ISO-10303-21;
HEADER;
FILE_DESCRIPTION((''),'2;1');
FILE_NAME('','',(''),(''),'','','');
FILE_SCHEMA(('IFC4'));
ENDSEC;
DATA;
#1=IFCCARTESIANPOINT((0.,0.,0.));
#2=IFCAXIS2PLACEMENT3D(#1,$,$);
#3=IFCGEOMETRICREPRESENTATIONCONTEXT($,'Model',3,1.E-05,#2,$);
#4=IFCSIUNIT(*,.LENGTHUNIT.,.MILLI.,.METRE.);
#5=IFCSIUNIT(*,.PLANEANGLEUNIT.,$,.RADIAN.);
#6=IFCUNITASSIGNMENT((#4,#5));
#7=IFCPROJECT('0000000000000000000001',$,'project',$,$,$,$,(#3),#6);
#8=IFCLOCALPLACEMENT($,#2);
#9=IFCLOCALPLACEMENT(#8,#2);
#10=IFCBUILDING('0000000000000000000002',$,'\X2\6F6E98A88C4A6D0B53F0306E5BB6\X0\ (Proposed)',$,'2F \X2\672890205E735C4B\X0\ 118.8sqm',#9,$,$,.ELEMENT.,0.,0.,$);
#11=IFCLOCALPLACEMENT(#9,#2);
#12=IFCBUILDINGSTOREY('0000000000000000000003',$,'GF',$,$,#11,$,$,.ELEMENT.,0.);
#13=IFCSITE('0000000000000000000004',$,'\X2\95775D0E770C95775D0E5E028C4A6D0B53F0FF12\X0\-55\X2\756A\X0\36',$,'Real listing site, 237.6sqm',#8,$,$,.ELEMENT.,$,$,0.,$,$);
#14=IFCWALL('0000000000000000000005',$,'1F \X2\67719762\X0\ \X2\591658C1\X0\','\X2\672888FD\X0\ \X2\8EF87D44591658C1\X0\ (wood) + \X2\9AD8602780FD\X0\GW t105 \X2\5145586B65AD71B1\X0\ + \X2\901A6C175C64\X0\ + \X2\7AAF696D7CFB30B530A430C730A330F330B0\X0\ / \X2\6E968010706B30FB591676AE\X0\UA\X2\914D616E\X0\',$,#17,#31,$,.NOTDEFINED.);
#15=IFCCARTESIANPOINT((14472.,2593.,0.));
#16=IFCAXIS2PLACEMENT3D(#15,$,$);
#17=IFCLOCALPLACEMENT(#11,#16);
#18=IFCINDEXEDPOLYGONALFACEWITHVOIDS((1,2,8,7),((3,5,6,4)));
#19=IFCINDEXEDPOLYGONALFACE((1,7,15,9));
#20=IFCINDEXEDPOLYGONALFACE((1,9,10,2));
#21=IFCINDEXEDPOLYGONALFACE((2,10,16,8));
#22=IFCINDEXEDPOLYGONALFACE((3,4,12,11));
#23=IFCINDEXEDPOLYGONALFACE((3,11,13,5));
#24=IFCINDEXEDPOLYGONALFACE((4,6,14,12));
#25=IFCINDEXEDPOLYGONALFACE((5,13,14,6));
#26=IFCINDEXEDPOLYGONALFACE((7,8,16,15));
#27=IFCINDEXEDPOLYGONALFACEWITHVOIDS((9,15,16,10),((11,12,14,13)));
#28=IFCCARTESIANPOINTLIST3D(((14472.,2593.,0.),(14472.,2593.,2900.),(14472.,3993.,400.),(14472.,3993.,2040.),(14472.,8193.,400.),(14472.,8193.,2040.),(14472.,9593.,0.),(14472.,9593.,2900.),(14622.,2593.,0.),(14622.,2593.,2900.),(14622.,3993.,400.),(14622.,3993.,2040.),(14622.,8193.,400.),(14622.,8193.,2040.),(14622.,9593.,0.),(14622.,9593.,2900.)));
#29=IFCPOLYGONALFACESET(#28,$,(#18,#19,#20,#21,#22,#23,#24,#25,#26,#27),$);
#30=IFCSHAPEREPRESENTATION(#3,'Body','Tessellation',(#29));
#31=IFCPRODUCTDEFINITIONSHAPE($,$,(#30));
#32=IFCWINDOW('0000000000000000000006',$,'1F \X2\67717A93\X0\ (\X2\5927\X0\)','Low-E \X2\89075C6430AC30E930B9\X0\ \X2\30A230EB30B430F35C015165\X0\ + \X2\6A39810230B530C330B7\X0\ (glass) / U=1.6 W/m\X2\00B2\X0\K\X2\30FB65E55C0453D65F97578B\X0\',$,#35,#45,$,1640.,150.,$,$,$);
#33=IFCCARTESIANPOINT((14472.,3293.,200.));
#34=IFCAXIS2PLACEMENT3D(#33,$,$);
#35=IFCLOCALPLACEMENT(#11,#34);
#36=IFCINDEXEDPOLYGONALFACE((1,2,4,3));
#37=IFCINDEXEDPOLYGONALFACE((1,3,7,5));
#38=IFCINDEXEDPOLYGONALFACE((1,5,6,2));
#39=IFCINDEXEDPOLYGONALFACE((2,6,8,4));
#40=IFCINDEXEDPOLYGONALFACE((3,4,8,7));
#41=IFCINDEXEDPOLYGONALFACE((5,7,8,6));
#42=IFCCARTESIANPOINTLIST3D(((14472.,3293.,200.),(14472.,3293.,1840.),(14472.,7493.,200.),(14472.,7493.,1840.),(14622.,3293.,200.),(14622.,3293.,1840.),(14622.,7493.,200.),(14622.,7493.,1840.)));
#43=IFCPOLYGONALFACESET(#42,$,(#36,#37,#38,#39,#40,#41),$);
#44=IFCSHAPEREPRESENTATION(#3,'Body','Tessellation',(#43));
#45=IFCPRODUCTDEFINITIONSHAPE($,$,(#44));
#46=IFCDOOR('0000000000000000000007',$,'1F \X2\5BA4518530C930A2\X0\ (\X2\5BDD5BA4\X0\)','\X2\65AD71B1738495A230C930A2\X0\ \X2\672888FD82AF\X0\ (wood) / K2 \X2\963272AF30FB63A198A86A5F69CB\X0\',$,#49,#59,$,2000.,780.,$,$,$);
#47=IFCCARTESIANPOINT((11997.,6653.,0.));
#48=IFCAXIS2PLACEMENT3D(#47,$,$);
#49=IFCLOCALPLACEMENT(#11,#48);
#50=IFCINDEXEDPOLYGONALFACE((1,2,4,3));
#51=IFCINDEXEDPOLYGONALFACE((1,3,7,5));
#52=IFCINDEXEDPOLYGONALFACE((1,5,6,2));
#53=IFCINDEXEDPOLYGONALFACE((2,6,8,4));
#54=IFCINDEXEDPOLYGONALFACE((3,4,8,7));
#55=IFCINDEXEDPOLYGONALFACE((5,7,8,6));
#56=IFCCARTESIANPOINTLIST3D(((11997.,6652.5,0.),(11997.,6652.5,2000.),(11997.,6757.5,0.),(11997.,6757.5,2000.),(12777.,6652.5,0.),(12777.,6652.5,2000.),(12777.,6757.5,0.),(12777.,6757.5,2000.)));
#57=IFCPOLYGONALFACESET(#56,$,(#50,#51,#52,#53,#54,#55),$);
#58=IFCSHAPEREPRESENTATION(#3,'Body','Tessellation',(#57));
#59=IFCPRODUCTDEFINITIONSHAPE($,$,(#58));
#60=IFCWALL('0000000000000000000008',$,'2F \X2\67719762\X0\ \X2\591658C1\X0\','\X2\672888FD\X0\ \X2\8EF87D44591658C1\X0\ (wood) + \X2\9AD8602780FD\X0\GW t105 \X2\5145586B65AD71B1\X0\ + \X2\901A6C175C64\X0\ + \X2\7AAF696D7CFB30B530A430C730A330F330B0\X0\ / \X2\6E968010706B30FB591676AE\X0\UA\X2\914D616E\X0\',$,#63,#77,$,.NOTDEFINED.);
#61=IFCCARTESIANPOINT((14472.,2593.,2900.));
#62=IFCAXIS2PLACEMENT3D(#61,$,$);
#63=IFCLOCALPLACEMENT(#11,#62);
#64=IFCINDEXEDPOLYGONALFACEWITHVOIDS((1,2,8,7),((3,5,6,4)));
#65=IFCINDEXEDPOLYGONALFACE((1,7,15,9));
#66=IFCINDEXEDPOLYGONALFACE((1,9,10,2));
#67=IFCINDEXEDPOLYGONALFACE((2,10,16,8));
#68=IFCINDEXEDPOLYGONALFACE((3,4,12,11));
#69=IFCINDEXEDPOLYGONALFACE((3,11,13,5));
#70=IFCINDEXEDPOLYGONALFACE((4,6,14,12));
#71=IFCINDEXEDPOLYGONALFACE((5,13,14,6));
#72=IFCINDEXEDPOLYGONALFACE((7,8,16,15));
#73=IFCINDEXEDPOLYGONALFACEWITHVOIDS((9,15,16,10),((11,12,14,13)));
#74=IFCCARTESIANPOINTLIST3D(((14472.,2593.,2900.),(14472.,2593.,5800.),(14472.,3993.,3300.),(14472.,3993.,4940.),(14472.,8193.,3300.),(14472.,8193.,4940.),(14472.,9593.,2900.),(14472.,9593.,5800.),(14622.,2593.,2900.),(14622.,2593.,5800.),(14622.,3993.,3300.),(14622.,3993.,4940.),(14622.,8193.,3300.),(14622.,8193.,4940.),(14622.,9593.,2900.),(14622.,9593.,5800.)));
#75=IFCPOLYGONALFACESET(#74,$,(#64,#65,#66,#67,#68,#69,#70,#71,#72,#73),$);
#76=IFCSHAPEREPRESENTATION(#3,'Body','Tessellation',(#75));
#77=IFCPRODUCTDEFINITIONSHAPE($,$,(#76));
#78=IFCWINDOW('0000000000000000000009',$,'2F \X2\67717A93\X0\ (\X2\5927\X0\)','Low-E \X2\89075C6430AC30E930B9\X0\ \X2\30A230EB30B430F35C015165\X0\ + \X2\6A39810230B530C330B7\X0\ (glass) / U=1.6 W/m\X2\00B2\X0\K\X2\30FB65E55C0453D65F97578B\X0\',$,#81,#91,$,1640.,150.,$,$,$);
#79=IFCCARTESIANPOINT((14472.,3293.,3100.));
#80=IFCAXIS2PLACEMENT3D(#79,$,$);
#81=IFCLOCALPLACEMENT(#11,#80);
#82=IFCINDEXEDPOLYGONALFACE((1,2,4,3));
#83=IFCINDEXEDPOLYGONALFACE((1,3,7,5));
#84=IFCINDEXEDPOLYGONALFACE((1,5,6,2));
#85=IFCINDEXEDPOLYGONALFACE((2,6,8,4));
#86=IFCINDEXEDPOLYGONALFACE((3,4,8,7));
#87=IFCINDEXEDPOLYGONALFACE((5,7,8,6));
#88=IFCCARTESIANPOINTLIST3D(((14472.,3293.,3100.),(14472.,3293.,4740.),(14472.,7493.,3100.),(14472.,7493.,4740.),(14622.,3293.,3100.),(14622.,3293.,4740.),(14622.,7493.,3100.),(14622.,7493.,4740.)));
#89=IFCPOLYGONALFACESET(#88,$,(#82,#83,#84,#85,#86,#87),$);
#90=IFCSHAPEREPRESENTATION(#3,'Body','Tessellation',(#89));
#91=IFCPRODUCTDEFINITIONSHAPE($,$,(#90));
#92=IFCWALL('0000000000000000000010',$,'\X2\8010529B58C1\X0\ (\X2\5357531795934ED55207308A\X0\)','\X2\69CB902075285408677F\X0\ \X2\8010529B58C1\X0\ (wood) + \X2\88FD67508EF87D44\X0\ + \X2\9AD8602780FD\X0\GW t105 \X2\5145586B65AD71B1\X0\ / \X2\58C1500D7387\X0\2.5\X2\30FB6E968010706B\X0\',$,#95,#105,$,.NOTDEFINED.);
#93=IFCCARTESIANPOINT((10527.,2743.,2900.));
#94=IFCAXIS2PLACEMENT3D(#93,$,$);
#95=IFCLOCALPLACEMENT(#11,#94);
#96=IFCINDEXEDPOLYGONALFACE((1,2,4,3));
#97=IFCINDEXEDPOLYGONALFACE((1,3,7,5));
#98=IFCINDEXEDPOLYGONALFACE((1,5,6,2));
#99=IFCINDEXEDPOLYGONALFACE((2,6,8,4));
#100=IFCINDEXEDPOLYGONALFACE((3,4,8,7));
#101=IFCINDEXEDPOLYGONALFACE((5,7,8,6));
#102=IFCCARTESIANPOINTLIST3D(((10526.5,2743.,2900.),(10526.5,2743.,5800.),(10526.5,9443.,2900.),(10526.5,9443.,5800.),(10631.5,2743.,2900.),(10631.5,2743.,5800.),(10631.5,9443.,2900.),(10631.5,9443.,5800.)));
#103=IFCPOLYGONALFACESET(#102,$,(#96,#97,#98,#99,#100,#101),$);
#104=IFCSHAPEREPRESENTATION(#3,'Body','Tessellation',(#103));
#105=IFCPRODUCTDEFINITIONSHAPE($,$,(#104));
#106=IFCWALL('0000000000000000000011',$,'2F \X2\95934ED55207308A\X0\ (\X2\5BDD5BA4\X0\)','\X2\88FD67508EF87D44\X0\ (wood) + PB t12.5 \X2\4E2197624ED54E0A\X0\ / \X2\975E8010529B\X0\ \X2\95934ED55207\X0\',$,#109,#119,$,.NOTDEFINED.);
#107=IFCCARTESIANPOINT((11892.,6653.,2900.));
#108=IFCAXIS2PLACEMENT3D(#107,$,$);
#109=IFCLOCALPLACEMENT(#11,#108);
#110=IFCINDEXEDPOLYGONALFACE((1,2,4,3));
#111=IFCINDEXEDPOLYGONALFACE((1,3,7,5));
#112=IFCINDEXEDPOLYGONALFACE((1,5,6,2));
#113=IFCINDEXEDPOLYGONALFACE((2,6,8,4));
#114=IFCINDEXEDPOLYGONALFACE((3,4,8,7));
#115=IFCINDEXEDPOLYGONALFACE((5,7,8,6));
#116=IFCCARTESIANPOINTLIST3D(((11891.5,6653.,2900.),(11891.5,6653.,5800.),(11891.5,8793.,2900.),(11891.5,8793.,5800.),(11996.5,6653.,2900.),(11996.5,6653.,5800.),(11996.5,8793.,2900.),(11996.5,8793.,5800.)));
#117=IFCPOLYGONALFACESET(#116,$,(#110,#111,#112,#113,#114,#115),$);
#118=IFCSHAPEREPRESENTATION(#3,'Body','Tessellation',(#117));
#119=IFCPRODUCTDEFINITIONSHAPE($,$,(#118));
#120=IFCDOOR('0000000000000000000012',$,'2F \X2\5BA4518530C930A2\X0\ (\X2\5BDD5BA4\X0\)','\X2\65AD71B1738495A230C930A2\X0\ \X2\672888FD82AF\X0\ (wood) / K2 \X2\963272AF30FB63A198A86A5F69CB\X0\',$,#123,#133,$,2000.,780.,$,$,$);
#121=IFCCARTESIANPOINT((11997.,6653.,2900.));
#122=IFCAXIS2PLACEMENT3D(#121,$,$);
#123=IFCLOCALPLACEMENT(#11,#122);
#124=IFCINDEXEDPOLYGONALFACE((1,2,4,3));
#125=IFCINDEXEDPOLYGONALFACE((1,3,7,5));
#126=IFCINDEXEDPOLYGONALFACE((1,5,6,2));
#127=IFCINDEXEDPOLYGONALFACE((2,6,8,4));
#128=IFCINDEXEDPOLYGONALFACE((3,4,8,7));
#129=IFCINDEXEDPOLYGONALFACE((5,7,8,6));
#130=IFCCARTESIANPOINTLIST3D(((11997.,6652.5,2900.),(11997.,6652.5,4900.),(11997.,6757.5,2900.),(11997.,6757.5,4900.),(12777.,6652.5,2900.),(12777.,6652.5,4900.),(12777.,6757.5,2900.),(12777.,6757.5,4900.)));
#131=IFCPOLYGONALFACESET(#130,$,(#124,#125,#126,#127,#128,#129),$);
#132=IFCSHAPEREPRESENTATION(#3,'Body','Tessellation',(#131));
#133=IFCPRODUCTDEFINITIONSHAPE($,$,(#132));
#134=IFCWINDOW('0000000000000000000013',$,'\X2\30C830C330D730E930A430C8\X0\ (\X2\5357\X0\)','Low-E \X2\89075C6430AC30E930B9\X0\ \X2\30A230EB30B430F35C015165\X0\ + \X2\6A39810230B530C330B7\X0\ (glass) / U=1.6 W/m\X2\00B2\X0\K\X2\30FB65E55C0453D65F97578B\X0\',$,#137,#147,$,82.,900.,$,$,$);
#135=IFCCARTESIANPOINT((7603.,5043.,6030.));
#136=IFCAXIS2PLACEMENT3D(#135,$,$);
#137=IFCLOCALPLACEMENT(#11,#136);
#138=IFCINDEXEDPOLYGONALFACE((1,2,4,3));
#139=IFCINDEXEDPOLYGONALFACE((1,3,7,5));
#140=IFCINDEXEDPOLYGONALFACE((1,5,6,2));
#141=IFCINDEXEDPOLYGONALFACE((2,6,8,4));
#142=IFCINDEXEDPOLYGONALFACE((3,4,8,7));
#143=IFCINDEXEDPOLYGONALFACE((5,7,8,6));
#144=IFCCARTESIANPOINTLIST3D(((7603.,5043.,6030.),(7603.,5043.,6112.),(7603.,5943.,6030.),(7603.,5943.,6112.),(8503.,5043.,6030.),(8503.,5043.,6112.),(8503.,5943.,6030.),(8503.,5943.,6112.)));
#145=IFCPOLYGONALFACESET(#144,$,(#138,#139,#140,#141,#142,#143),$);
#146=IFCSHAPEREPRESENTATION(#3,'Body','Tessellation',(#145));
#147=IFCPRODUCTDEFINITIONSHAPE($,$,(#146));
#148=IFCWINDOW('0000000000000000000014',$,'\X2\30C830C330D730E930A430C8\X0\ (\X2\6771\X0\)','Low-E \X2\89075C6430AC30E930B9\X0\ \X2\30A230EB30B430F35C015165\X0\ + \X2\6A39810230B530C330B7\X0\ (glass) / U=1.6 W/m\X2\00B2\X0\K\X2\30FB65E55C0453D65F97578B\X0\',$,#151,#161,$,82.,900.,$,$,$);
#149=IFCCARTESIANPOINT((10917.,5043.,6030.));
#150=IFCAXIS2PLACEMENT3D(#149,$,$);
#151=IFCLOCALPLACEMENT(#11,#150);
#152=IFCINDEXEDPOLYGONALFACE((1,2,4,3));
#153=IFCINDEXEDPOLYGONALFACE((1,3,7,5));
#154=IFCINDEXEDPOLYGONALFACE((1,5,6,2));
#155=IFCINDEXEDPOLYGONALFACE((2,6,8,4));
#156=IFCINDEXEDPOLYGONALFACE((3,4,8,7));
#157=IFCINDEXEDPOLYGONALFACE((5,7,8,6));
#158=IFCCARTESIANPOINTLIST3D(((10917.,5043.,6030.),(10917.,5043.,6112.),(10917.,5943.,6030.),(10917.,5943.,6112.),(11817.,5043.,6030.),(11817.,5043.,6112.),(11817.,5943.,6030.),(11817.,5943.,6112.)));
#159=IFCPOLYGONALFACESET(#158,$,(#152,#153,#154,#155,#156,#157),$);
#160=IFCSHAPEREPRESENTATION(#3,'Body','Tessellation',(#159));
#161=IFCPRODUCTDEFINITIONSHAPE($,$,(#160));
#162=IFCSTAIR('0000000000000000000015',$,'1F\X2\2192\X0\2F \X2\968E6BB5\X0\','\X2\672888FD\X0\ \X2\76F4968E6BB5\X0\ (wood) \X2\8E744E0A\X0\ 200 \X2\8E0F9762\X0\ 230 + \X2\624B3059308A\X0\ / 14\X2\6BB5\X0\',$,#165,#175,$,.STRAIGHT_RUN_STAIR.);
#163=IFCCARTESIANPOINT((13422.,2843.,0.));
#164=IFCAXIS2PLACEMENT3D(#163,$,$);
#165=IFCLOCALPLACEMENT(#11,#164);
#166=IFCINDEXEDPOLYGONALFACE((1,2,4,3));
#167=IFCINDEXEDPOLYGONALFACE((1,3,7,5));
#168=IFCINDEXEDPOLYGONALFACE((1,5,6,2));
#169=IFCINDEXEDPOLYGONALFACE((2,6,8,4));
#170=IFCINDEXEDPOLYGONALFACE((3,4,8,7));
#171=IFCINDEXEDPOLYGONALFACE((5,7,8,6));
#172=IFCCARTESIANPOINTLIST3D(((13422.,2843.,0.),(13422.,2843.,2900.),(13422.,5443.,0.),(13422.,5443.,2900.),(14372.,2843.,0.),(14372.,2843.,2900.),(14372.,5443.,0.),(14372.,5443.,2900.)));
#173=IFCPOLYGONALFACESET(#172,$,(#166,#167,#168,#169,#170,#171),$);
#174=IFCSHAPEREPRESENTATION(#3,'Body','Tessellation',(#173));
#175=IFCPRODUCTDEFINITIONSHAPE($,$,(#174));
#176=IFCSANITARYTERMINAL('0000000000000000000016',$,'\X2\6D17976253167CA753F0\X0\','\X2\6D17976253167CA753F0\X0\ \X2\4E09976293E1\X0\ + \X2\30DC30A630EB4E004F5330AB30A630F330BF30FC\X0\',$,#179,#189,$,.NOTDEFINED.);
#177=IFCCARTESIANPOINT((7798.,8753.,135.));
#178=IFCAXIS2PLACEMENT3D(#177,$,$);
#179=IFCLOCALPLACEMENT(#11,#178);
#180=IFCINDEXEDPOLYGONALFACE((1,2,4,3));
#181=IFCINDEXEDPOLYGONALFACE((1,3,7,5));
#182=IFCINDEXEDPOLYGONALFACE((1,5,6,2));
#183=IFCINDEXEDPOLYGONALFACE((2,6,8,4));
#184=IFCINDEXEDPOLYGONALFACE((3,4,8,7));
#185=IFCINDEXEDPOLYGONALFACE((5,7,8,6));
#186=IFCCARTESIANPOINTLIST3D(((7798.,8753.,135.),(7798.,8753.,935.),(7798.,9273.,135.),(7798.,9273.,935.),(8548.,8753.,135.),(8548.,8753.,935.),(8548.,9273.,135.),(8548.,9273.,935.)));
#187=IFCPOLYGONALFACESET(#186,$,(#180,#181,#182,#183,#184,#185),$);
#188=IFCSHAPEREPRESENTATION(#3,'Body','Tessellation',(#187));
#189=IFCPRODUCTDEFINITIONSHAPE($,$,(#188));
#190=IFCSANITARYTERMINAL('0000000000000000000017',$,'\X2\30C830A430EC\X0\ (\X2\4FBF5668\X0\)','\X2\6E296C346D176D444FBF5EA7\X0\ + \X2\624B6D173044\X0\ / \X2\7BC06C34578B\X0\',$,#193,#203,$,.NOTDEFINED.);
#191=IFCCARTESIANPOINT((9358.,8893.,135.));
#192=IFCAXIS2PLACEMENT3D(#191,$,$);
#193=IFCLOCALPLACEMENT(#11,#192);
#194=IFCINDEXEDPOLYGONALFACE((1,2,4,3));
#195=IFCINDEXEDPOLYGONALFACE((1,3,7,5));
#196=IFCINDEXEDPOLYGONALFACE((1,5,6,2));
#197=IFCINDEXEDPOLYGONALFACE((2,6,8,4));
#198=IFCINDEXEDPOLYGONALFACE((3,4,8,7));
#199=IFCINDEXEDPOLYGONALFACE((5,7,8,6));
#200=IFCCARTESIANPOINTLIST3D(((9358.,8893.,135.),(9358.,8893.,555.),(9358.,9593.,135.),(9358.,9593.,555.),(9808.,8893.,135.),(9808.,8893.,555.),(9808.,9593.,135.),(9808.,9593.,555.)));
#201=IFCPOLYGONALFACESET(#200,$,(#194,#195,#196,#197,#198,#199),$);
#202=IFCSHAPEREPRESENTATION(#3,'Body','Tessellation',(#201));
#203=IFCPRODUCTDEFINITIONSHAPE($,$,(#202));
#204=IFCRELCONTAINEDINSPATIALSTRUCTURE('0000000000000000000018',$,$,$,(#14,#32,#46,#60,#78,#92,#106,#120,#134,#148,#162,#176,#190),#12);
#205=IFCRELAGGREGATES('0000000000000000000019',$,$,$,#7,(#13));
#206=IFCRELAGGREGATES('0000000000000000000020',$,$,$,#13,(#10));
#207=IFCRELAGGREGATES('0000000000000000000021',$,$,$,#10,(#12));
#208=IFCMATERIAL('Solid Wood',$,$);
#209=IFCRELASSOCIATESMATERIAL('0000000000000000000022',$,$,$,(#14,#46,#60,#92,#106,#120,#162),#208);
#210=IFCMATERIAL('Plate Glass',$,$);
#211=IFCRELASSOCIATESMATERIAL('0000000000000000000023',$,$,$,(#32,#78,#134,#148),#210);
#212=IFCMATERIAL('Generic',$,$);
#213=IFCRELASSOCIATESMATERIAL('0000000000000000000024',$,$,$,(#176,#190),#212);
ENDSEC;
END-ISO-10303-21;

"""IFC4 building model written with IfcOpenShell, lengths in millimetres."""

from ifc_helpers import new_model, si_unit, frame, frame_2d, origin, place, context, project, spatial, rectangle, extrude, material, element, fill, save


model = new_model("IFC4")

# Units and contexts
model_context = context("Model", 3, precision=1e-05, world=origin())
ifc_project = project(units=[si_unit("LENGTHUNIT", "METRE", prefix="MILLI"), si_unit("PLANEANGLEUNIT", "RADIAN")], contexts=[model_context])

# Site, building, storey
site_placement = place(None, origin())
site = spatial("IfcSite", under=ifc_project, at=site_placement, Name="長崎県長崎市豊洋台２-55番36", ObjectType="Real listing site, 237.6sqm", CompositionType="ELEMENT", RefElevation=0.0)
building_placement = place(site_placement, origin())
building = spatial("IfcBuilding", under=site, at=building_placement, Name="潮風豊洋台の家 (Proposed)", ObjectType="2F 木造平屋 118.8sqm", CompositionType="ELEMENT", ElevationOfRefHeight=0.0, ElevationOfTerrain=0.0)
storey_placement = place(building_placement, origin())
storey = spatial("IfcBuildingStorey", under=building, at=storey_placement, Name="GF", CompositionType="ELEMENT", Elevation=0.0)

# Wall, opening, window
ifc_material_1 = material(Name="Solid Wood")
wall_1_placement = place(storey_placement, frame((14472.0, 2593.0, 0.0)))
wall_1 = element("IfcWall", 1, at=wall_1_placement, inside=storey, material=ifc_material_1, Name="1F 東面 外壁", Description="木製 軸組外壁 (wood) + 高性能GW t105 充填断熱 + 通気層 + 窯業系サイディング / 準耐火・外皮UA配慮", PredefinedType="NOTDEFINED", context=model_context, shape_type="SweptSolid", body=[
    extrude(rectangle(XDim=150.0, YDim=7000.0, at=frame_2d((75.0, 3500.0))), frame((14472.0, 2593.0, 0.0)), (0.0, 0.0, 1.0), 2900.0),
])
opening_1_placement = place(storey_placement, frame((14472.0, 3293.0, 200.0)))
opening_1 = element("IfcOpeningElement", 2, at=opening_1_placement, cuts=wall_1, PredefinedType="NOTDEFINED", context=model_context, shape_type="SweptSolid", body=[
    extrude(rectangle(XDim=150.0, YDim=4200.0, at=frame_2d((75.0, 2100.0))), frame((14472.0, 3293.0, 200.0)), (0.0, 0.0, 1.0), 1640.0),
])
ifc_material_2 = material(Name="Plate Glass")
window_1_placement = place(storey_placement, frame((14472.0, 3293.0, 200.0)))
window_1 = element("IfcWindow", 3, at=window_1_placement, inside=storey, material=ifc_material_2, Name="1F 東窓 (大)", Description="Low-E 複層ガラス アルゴン封入 + 樹脂サッシ (glass) / U=1.6 W/m²K・日射取得型", OverallHeight=1640.0, OverallWidth=150.0, context=model_context, shape_type="SweptSolid", body=[
    extrude(rectangle(XDim=150.0, YDim=4200.0, at=frame_2d((75.0, 2100.0))), frame((14472.0, 3293.0, 200.0)), (0.0, 0.0, 1.0), 1640.0),
])
fill(opening_1, window_1)

# Door
door_1_placement = place(storey_placement, frame((11997.0, 6653.0, 0.0)))
element("IfcDoor", 4, at=door_1_placement, inside=storey, material=ifc_material_1, Name="1F 室内ドア (寝室)", Description="断熱玄関ドア 木製芯 (wood) / K2 防犯・採風機構", OverallHeight=2000.0, OverallWidth=780.0, context=model_context, shape_type="SweptSolid", body=[
    extrude(rectangle(XDim=780.0, YDim=105.0, at=frame_2d((390.0, 52.0))), frame((11997.0, 6653.0, 0.0)), (0.0, 0.0, 1.0), 2000.0),
])

# Wall, opening, window
wall_2_placement = place(storey_placement, frame((14472.0, 2593.0, 2900.0)))
wall_2 = element("IfcWall", 5, at=wall_2_placement, inside=storey, material=ifc_material_1, Name="2F 東面 外壁", Description="木製 軸組外壁 (wood) + 高性能GW t105 充填断熱 + 通気層 + 窯業系サイディング / 準耐火・外皮UA配慮", PredefinedType="NOTDEFINED", context=model_context, shape_type="SweptSolid", body=[
    extrude(rectangle(XDim=150.0, YDim=7000.0, at=frame_2d((75.0, 3500.0))), frame((14472.0, 2593.0, 2900.0)), (0.0, 0.0, 1.0), 2900.0),
])
opening_2_placement = place(storey_placement, frame((14472.0, 3293.0, 3100.0)))
opening_2 = element("IfcOpeningElement", 6, at=opening_2_placement, cuts=wall_2, PredefinedType="NOTDEFINED", context=model_context, shape_type="SweptSolid", body=[
    extrude(rectangle(XDim=150.0, YDim=4200.0, at=frame_2d((75.0, 2100.0))), frame((14472.0, 3293.0, 3100.0)), (0.0, 0.0, 1.0), 1640.0),
])
window_2_placement = place(storey_placement, frame((14472.0, 3293.0, 3100.0)))
window_2 = element("IfcWindow", 7, at=window_2_placement, inside=storey, material=ifc_material_2, Name="2F 東窓 (大)", Description="Low-E 複層ガラス アルゴン封入 + 樹脂サッシ (glass) / U=1.6 W/m²K・日射取得型", OverallHeight=1640.0, OverallWidth=150.0, context=model_context, shape_type="SweptSolid", body=[
    extrude(rectangle(XDim=150.0, YDim=4200.0, at=frame_2d((75.0, 2100.0))), frame((14472.0, 3293.0, 3100.0)), (0.0, 0.0, 1.0), 1640.0),
])
fill(opening_2, window_2)

# Walls
wall_3_placement = place(storey_placement, frame((10527.0, 2743.0, 2900.0)))
element("IfcWall", 8, at=wall_3_placement, inside=storey, material=ifc_material_1, Name="耐力壁 (南北間仕切り)", Description="構造用合板 耐力壁 (wood) + 製材軸組 + 高性能GW t105 充填断熱 / 壁倍率2.5・準耐火", PredefinedType="NOTDEFINED", context=model_context, shape_type="SweptSolid", body=[
    extrude(rectangle(XDim=105.0, YDim=6700.0, at=frame_2d((52.0, 3350.0))), frame((10527.0, 2743.0, 2900.0)), (0.0, 0.0, 1.0), 2900.0),
])
wall_4_placement = place(storey_placement, frame((11892.0, 6653.0, 2900.0)))
element("IfcWall", 9, at=wall_4_placement, inside=storey, material=ifc_material_1, Name="2F 間仕切り (寝室)", Description="製材軸組 (wood) + PB t12.5 両面仕上 / 非耐力 間仕切", PredefinedType="NOTDEFINED", context=model_context, shape_type="SweptSolid", body=[
    extrude(rectangle(XDim=105.0, YDim=2140.0, at=frame_2d((52.0, 1070.0))), frame((11892.0, 6653.0, 2900.0)), (0.0, 0.0, 1.0), 2900.0),
])

# Door
door_2_placement = place(storey_placement, frame((11997.0, 6653.0, 2900.0)))
element("IfcDoor", 10, at=door_2_placement, inside=storey, material=ifc_material_1, Name="2F 室内ドア (寝室)", Description="断熱玄関ドア 木製芯 (wood) / K2 防犯・採風機構", OverallHeight=2000.0, OverallWidth=780.0, context=model_context, shape_type="SweptSolid", body=[
    extrude(rectangle(XDim=780.0, YDim=105.0, at=frame_2d((390.0, 52.0))), frame((11997.0, 6653.0, 2900.0)), (0.0, 0.0, 1.0), 2000.0),
])

# Windows
window_3_placement = place(storey_placement, frame((7603.0, 5043.0, 6030.0)))
element("IfcWindow", 11, at=window_3_placement, inside=storey, material=ifc_material_2, Name="トップライト (南)", Description="Low-E 複層ガラス アルゴン封入 + 樹脂サッシ (glass) / U=1.6 W/m²K・日射取得型", OverallHeight=82.0, OverallWidth=900.0, context=model_context, shape_type="SweptSolid", body=[
    extrude(rectangle(XDim=900.0, YDim=900.0, at=frame_2d((450.0, 450.0))), frame((7603.0, 5043.0, 6030.0)), (0.0, 0.0, 1.0), 82.0),
])
window_4_placement = place(storey_placement, frame((10917.0, 5043.0, 6030.0)))
element("IfcWindow", 12, at=window_4_placement, inside=storey, material=ifc_material_2, Name="トップライト (東)", Description="Low-E 複層ガラス アルゴン封入 + 樹脂サッシ (glass) / U=1.6 W/m²K・日射取得型", OverallHeight=82.0, OverallWidth=900.0, context=model_context, shape_type="SweptSolid", body=[
    extrude(rectangle(XDim=900.0, YDim=900.0, at=frame_2d((450.0, 450.0))), frame((10917.0, 5043.0, 6030.0)), (0.0, 0.0, 1.0), 82.0),
])

# Stair
stair_placement = place(storey_placement, frame((13422.0, 2843.0, 0.0)))
element("IfcStair", 13, at=stair_placement, inside=storey, material=ifc_material_1, Name="1F→2F 階段", Description="木製 直階段 (wood) 蹴上 200 踏面 230 + 手すり / 14段", PredefinedType="STRAIGHT_RUN_STAIR", context=model_context, shape_type="SweptSolid", body=[
    extrude(rectangle(XDim=950.0, YDim=2600.0, at=frame_2d((475.0, 1300.0))), frame((13422.0, 2843.0, 0.0)), (0.0, 0.0, 1.0), 2900.0),
])

# Sanitary terminals
ifc_material_3 = material(Name="Generic")
sanitary_terminal_1_placement = place(storey_placement, frame((7798.0, 8753.0, 135.0)))
element("IfcSanitaryTerminal", 14, at=sanitary_terminal_1_placement, inside=storey, material=ifc_material_3, Name="洗面化粧台", Description="洗面化粧台 三面鏡 + ボウル一体カウンター", PredefinedType="NOTDEFINED", context=model_context, shape_type="SweptSolid", body=[
    extrude(rectangle(XDim=750.0, YDim=520.0, at=frame_2d((375.0, 260.0))), frame((7798.0, 8753.0, 135.0)), (0.0, 0.0, 1.0), 800.0),
])
sanitary_terminal_2_placement = place(storey_placement, frame((9358.0, 8893.0, 135.0)))
element("IfcSanitaryTerminal", 15, at=sanitary_terminal_2_placement, inside=storey, material=ifc_material_3, Name="トイレ (便器)", Description="温水洗浄便座 + 手洗い / 節水型", PredefinedType="NOTDEFINED", context=model_context, shape_type="SweptSolid", body=[
    extrude(rectangle(XDim=450.0, YDim=700.0, at=frame_2d((225.0, 350.0))), frame((9358.0, 8893.0, 135.0)), (0.0, 0.0, 1.0), 420.0),
])

save(model, "model.ifc")
